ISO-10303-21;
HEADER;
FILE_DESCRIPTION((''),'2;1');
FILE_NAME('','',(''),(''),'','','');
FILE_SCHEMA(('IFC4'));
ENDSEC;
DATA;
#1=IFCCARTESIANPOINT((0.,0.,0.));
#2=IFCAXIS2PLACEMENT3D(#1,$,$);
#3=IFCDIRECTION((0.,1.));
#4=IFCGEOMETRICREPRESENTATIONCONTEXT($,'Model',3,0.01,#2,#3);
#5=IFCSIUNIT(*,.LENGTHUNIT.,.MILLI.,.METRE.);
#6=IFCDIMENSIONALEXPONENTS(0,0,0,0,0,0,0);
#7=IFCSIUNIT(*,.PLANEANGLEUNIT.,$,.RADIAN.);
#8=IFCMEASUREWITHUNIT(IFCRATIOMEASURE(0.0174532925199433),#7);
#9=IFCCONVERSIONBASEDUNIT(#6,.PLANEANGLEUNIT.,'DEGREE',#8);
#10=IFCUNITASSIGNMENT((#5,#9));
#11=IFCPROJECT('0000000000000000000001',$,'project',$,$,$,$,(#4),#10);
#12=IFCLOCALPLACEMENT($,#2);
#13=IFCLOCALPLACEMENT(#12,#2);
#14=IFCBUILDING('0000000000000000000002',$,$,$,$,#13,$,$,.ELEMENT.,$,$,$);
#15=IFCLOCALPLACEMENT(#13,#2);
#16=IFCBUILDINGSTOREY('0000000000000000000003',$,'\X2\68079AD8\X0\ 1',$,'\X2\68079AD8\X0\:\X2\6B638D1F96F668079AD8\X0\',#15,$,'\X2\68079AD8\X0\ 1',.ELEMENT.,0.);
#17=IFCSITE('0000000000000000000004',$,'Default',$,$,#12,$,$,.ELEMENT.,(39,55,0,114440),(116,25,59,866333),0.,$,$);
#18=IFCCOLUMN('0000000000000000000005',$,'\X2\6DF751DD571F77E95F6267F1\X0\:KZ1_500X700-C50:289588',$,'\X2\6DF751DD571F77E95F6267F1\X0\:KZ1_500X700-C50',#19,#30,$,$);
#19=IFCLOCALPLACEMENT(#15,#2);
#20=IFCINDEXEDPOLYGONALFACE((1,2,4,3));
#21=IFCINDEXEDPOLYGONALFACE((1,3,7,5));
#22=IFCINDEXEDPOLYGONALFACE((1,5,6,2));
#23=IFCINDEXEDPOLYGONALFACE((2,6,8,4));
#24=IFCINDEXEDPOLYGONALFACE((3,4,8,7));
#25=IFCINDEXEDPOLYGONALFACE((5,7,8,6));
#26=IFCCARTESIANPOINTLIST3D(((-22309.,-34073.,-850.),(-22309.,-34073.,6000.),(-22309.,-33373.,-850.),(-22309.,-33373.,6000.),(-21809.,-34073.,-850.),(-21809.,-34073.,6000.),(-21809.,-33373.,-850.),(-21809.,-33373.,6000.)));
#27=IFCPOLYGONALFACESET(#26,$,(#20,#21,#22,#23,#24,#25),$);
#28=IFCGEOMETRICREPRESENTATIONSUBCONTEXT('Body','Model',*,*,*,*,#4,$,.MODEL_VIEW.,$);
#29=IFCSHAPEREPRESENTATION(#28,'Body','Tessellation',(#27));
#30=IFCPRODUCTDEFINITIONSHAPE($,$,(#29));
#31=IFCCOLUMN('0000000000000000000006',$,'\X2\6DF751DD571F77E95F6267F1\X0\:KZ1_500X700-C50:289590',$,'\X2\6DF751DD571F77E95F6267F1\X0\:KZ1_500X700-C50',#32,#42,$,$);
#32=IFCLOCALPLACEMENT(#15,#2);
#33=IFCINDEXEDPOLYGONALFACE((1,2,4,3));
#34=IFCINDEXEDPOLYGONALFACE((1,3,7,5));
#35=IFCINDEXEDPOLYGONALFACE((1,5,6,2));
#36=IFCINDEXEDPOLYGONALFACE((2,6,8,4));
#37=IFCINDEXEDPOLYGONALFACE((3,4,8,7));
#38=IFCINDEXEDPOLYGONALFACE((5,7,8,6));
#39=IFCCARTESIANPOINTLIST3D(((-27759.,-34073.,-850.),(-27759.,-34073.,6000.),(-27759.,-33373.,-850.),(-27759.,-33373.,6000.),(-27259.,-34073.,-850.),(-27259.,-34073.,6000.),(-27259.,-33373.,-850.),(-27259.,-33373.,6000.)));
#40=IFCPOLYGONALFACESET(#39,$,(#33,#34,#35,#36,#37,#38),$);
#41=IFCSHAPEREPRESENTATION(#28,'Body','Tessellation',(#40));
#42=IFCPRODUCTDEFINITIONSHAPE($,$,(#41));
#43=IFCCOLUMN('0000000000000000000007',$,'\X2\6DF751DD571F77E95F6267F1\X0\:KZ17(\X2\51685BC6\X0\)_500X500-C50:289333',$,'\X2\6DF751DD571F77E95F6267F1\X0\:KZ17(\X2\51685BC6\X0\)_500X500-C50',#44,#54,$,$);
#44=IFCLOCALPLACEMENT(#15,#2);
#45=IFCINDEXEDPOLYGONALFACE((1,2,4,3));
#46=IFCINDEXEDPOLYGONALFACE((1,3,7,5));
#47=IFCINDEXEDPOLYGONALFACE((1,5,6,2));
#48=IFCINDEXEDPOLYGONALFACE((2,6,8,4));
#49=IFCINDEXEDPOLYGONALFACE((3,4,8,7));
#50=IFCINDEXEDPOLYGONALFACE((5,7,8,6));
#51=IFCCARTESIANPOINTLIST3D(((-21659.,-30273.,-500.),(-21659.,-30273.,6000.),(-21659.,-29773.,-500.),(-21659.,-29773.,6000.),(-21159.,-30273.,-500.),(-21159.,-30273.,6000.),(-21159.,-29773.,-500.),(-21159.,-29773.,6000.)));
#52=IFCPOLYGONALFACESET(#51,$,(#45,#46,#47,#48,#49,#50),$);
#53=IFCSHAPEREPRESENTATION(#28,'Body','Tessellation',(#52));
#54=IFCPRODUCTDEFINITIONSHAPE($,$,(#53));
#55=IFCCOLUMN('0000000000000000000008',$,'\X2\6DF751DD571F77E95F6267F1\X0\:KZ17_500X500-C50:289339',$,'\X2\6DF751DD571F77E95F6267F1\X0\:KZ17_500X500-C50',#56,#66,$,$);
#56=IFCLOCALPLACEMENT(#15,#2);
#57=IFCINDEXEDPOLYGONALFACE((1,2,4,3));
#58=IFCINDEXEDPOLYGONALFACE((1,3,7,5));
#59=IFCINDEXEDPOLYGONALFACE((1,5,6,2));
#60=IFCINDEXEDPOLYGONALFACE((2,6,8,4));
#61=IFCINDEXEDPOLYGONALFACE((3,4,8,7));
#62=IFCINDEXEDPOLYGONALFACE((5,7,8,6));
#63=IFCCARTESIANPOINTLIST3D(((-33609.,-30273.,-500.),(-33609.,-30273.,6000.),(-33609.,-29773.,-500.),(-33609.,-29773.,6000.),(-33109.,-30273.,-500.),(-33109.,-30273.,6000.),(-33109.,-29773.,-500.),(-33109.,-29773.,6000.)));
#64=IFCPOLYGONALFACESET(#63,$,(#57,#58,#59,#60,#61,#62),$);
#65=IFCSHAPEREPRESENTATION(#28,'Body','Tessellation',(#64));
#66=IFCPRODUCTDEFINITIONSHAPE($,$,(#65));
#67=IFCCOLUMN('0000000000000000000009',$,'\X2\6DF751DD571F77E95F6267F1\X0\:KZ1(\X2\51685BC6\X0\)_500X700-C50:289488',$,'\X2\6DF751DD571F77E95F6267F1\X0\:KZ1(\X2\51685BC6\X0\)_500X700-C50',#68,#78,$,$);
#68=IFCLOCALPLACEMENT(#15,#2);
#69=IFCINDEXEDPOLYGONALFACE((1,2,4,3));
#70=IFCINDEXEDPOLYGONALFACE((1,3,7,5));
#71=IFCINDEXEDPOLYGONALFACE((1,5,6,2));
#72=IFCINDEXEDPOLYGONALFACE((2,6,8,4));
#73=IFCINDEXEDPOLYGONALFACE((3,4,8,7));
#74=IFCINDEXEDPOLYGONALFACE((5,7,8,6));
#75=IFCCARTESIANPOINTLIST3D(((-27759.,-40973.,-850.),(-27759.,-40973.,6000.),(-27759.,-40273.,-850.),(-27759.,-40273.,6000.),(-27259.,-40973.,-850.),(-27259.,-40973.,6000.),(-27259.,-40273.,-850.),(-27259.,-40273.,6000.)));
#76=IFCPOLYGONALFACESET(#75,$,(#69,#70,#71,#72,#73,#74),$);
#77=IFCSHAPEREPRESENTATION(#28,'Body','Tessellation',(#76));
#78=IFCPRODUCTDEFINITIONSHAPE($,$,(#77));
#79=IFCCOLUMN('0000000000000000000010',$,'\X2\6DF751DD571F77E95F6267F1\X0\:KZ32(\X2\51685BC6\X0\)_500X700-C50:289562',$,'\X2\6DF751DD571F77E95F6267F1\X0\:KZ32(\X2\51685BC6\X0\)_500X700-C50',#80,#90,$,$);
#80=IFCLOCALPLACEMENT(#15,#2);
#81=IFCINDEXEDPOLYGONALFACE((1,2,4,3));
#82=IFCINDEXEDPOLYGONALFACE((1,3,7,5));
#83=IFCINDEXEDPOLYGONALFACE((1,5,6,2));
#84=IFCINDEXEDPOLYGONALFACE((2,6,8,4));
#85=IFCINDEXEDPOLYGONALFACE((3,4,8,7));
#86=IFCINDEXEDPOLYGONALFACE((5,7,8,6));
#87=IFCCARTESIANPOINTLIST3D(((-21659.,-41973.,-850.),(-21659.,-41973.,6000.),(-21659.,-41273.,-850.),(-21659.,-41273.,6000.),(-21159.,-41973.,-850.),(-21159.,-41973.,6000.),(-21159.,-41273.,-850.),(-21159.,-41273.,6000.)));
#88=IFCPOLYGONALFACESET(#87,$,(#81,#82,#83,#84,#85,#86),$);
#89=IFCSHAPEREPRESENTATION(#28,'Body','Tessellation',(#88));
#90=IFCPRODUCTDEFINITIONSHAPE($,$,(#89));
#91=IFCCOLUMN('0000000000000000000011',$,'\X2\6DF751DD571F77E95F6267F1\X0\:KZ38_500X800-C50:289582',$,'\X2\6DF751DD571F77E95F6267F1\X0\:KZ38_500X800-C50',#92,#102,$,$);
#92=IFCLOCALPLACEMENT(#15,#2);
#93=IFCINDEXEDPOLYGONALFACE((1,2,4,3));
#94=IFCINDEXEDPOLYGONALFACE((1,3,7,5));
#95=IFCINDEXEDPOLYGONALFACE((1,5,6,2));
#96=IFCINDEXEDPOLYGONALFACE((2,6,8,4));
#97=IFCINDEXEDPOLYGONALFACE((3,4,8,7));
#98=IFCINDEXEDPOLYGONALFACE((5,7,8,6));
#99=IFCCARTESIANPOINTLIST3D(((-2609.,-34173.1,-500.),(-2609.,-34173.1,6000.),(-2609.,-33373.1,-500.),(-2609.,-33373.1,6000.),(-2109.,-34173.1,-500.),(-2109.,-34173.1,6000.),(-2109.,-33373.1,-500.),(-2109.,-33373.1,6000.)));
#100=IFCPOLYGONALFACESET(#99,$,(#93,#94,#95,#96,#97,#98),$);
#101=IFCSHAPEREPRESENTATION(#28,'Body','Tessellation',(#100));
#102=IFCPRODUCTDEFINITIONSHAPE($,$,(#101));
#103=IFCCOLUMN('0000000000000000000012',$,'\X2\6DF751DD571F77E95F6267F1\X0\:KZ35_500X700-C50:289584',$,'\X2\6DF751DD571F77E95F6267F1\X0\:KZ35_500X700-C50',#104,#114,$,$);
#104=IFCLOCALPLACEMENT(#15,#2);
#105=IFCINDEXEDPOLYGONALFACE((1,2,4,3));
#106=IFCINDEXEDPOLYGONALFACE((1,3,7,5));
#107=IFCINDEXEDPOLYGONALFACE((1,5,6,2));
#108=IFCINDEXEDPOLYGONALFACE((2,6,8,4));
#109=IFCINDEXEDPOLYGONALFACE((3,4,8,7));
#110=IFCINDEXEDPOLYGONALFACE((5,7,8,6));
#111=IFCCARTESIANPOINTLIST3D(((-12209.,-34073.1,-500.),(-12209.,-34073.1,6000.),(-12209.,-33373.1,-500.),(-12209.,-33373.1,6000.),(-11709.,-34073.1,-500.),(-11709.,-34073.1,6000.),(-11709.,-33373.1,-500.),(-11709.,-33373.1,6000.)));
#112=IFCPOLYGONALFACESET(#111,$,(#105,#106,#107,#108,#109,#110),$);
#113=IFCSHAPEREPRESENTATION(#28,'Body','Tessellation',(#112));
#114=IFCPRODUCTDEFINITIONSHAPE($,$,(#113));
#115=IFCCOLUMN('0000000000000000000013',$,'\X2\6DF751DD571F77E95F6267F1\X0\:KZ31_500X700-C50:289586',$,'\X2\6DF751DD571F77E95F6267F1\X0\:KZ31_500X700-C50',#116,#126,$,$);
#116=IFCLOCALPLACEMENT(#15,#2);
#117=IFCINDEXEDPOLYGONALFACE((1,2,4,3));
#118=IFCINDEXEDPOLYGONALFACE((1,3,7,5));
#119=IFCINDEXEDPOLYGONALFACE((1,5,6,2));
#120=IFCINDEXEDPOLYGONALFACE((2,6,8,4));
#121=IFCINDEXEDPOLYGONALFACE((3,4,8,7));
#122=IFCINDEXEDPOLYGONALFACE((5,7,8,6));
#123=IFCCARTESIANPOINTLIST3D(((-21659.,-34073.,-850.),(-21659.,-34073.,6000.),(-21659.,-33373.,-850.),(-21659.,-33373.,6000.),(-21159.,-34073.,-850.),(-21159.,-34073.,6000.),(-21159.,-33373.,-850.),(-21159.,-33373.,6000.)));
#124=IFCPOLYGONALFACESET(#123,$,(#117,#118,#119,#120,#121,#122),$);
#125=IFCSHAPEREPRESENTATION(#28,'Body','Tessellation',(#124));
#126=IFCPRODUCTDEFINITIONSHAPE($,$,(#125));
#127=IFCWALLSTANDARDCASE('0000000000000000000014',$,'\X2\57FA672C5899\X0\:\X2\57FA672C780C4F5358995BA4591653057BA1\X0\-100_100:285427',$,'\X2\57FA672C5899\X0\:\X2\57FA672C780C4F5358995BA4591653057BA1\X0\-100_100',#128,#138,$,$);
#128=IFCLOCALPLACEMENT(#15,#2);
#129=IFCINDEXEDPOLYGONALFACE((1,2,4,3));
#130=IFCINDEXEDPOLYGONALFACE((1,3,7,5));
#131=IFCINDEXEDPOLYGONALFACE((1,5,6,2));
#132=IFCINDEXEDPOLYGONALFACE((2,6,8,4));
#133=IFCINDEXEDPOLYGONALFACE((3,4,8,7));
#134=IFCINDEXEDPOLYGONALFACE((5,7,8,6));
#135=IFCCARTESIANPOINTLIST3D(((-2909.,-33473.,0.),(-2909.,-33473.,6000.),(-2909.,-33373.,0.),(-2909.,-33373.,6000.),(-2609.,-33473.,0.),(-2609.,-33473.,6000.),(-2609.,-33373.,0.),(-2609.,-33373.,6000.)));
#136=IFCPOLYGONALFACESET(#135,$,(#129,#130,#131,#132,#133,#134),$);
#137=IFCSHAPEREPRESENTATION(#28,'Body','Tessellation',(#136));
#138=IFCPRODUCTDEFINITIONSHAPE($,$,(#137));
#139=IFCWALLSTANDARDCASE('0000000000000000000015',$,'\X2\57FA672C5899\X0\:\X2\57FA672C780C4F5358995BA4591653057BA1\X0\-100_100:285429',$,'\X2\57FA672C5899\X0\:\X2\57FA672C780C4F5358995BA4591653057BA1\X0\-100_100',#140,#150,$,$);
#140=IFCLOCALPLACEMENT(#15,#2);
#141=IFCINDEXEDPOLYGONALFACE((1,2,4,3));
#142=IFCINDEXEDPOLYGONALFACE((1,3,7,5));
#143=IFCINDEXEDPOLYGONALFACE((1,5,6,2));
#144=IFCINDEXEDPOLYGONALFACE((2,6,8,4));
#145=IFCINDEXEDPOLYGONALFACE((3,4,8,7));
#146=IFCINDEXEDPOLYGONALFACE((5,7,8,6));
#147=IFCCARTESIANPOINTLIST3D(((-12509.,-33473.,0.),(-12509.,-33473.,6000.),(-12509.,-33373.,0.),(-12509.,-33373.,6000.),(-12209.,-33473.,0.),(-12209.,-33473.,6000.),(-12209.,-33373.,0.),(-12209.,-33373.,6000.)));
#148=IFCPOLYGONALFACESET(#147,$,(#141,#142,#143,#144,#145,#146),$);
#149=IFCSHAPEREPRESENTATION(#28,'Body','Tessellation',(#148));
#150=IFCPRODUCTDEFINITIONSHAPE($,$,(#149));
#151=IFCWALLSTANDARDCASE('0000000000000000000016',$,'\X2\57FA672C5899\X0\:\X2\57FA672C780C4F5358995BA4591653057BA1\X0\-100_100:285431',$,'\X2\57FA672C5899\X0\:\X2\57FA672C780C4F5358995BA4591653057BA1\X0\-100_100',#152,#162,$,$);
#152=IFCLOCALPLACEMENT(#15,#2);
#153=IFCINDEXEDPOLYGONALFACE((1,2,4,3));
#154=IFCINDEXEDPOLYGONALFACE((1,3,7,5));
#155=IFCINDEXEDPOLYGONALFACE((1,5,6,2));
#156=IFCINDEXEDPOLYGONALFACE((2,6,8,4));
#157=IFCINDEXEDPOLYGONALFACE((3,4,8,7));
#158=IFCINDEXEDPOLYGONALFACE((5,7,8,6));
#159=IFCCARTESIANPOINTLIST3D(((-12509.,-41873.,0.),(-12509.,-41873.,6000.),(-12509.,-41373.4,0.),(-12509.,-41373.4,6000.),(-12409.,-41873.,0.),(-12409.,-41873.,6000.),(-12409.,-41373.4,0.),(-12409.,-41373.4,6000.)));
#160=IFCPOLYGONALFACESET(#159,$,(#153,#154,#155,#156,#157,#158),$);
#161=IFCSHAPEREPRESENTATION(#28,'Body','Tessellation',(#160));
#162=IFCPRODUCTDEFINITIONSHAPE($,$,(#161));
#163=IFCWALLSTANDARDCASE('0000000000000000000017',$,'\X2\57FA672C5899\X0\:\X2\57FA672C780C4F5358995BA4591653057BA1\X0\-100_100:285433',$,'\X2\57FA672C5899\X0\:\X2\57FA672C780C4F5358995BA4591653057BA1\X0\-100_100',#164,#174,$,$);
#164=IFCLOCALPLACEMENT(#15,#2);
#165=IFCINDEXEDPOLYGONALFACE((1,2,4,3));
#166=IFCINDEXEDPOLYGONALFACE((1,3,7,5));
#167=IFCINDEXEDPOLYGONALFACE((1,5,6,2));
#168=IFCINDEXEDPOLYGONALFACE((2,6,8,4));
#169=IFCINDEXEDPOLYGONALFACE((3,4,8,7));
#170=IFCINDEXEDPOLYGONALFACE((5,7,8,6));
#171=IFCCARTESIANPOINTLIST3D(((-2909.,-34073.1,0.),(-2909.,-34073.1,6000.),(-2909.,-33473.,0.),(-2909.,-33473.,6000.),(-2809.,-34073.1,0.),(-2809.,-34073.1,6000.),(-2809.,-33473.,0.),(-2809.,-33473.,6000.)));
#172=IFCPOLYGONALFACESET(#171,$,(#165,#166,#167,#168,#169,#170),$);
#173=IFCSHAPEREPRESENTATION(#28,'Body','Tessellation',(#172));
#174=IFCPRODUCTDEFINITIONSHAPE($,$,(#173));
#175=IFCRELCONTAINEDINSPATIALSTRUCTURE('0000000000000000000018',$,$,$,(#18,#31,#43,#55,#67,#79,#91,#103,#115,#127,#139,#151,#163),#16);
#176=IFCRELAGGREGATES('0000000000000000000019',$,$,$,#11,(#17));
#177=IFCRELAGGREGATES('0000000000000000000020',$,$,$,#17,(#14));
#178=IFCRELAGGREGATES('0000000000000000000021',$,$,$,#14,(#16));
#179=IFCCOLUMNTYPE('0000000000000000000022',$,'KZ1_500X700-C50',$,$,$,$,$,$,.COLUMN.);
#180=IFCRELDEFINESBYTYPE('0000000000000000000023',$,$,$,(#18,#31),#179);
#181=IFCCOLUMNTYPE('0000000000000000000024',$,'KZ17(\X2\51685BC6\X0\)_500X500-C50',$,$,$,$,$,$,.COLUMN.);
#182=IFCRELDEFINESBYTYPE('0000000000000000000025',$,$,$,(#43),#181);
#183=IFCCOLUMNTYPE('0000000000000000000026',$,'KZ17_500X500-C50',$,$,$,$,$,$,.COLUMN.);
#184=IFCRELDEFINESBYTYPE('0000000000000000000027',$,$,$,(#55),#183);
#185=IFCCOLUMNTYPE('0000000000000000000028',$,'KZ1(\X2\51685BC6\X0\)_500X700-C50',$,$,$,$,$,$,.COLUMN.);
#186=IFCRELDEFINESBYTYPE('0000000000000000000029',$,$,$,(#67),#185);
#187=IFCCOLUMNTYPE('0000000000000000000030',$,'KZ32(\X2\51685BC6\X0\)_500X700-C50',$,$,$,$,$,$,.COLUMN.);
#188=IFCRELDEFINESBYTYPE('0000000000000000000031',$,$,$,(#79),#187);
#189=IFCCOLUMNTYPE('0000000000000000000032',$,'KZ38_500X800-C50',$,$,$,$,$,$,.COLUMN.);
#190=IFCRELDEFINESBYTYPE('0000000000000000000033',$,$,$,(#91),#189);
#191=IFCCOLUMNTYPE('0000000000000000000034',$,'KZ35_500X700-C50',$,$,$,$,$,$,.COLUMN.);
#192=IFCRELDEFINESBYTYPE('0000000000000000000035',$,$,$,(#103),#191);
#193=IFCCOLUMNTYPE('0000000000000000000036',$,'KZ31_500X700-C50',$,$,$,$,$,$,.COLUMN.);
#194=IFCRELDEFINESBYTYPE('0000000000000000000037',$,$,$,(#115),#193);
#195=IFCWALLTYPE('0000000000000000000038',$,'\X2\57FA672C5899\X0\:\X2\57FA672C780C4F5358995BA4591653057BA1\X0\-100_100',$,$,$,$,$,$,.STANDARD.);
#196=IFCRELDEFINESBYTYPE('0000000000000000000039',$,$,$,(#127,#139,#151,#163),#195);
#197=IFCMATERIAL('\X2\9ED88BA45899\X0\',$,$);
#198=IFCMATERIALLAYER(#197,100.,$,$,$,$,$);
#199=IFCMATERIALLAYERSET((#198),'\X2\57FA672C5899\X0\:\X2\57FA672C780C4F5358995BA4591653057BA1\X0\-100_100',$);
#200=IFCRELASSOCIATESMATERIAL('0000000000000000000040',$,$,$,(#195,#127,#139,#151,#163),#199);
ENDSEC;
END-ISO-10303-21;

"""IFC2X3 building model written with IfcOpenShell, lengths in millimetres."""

from ifc_helpers import new_model, entity, si_unit, converted_unit, direction, frame, frame_2d, origin, origin_2d_with_axis, place, context, subcontext, project, spatial, rectangle, extrude, source, transform, mapped, material, layer, layer_set, layer_usage, type_object, type_shapes, element, save


model = new_model("IFC2X3")

# Units and contexts
model_context = context("Model", 3, precision=0.01, world=origin(), true_north=direction((0.0, 1.0)))
body_context = subcontext(model_context, "Body", "Model", "MODEL_VIEW")
ifc_project = project(units=[si_unit("LENGTHUNIT", "METRE", prefix="MILLI"), converted_unit("PLANEANGLEUNIT", "DEGREE", entity("IfcRatioMeasure", 0.0174532925199433), si_unit("PLANEANGLEUNIT", "RADIAN"), dimensions=[0, 0, 0, 0, 0, 0, 0])], contexts=[model_context])

# Site, building, storey
site_placement = place(None, origin())
site = spatial("IfcSite", under=ifc_project, at=site_placement, Name="Default", CompositionType="ELEMENT", RefLatitude=(39, 55, 0, 114440), RefLongitude=(116, 25, 59, 866333), RefElevation=0.0)
building_placement = place(site_placement, origin())
building = spatial("IfcBuilding", under=site, at=building_placement, CompositionType="ELEMENT")
storey_placement = place(building_placement, origin())
storey = spatial("IfcBuildingStorey", under=building, at=storey_placement, Name="标高 1", ObjectType="标高:正负零标高", LongName="标高 1", CompositionType="ELEMENT", Elevation=0.0)

# Columns
column_type_1 = type_object("IfcColumnType", Name="KZ1_500X700-C50", PredefinedType="COLUMN")
shared_shape_1 = source(origin(), body_context, "Body", "SweptSolid", [
    extrude(rectangle(XDim=700.0, YDim=500.0, at=origin_2d_with_axis()), frame((0.0, 0.0, -850.0), z_axis=(0.0, 0.0, 1.0), x_axis=(0.0, -1.0, 0.0)), (0.0, 0.0, 1.0), 6850.0),
])
type_shapes(column_type_1, [shared_shape_1])
for number, where, name in (
    (1, (-22059.0, -33723.0, 0.0), "混凝土矩形柱:KZ1_500X700-C50:289588"),
    (2, (-27509.0, -33723.0, 0.0), "混凝土矩形柱:KZ1_500X700-C50:289590"),
):
    element("IfcColumn", number, at=place(building_placement, frame(where)), inside=storey, type_object=column_type_1, Name=name, ObjectType="混凝土矩形柱:KZ1_500X700-C50", context=body_context, shape_type="MappedRepresentation", body=[
        mapped(shared_shape_1, transform((0.0, 0.0, 0.0), scale=1.0)),
    ])
column_type_2 = type_object("IfcColumnType", Name="KZ17(全密)_500X500-C50", PredefinedType="COLUMN")
shared_shape_2 = source(origin(), body_context, "Body", "SweptSolid", [
    extrude(rectangle(XDim=500.0, YDim=500.0, at=origin_2d_with_axis()), frame((0.0, 0.0, -500.0), z_axis=(0.0, 0.0, 1.0), x_axis=(0.0, -1.0, 0.0)), (0.0, 0.0, 1.0), 6500.0),
])
type_shapes(column_type_2, [shared_shape_2])
column_1_placement = place(building_placement, frame((-21409.0, -30023.0, 0.0)))
element("IfcColumn", 3, at=column_1_placement, inside=storey, type_object=column_type_2, Name="混凝土矩形柱:KZ17(全密)_500X500-C50:289333", ObjectType="混凝土矩形柱:KZ17(全密)_500X500-C50", context=body_context, shape_type="MappedRepresentation", body=[
    mapped(shared_shape_2, transform((0.0, 0.0, 0.0), scale=1.0)),
])
column_type_3 = type_object("IfcColumnType", Name="KZ17_500X500-C50", PredefinedType="COLUMN")
shared_shape_3 = source(origin(), body_context, "Body", "SweptSolid", [
    extrude(rectangle(XDim=500.0, YDim=500.0, at=origin_2d_with_axis()), frame((0.0, 0.0, -500.0), z_axis=(0.0, 0.0, 1.0), x_axis=(0.0, -1.0, 0.0)), (0.0, 0.0, 1.0), 6500.0),
])
type_shapes(column_type_3, [shared_shape_3])
column_2_placement = place(building_placement, frame((-33359.0, -30023.0, 0.0)))
element("IfcColumn", 4, at=column_2_placement, inside=storey, type_object=column_type_3, Name="混凝土矩形柱:KZ17_500X500-C50:289339", ObjectType="混凝土矩形柱:KZ17_500X500-C50", context=body_context, shape_type="MappedRepresentation", body=[
    mapped(shared_shape_3, transform((0.0, 0.0, 0.0), scale=1.0)),
])
column_type_4 = type_object("IfcColumnType", Name="KZ1(全密)_500X700-C50", PredefinedType="COLUMN")
shared_shape_4 = source(origin(), body_context, "Body", "SweptSolid", [
    extrude(rectangle(XDim=700.0, YDim=500.0, at=origin_2d_with_axis()), frame((0.0, 0.0, -850.0), z_axis=(0.0, 0.0, 1.0), x_axis=(0.0, -1.0, 0.0)), (0.0, 0.0, 1.0), 6850.0),
])
type_shapes(column_type_4, [shared_shape_4])
column_3_placement = place(building_placement, frame((-27509.0, -40623.0, 0.0)))
element("IfcColumn", 5, at=column_3_placement, inside=storey, type_object=column_type_4, Name="混凝土矩形柱:KZ1(全密)_500X700-C50:289488", ObjectType="混凝土矩形柱:KZ1(全密)_500X700-C50", context=body_context, shape_type="MappedRepresentation", body=[
    mapped(shared_shape_4, transform((0.0, 0.0, 0.0), scale=1.0)),
])
column_type_5 = type_object("IfcColumnType", Name="KZ32(全密)_500X700-C50", PredefinedType="COLUMN")
shared_shape_5 = source(origin(), body_context, "Body", "SweptSolid", [
    extrude(rectangle(XDim=700.0, YDim=500.0, at=origin_2d_with_axis()), frame((0.0, 0.0, -850.0), z_axis=(0.0, 0.0, 1.0), x_axis=(0.0, -1.0, 0.0)), (0.0, 0.0, 1.0), 6850.0),
])
type_shapes(column_type_5, [shared_shape_5])
column_4_placement = place(building_placement, frame((-21409.0, -41623.0, 0.0)))
element("IfcColumn", 6, at=column_4_placement, inside=storey, type_object=column_type_5, Name="混凝土矩形柱:KZ32(全密)_500X700-C50:289562", ObjectType="混凝土矩形柱:KZ32(全密)_500X700-C50", context=body_context, shape_type="MappedRepresentation", body=[
    mapped(shared_shape_5, transform((0.0, 0.0, 0.0), scale=1.0)),
])
column_type_6 = type_object("IfcColumnType", Name="KZ38_500X800-C50", PredefinedType="COLUMN")
shared_shape_6 = source(origin(), body_context, "Body", "SweptSolid", [
    extrude(rectangle(XDim=800.0, YDim=500.0, at=origin_2d_with_axis()), frame((0.0, 0.0, -500.0), z_axis=(0.0, 0.0, 1.0), x_axis=(0.0, -1.0, 0.0)), (0.0, 0.0, 1.0), 6500.0),
])
type_shapes(column_type_6, [shared_shape_6])
column_5_placement = place(building_placement, frame((-2359.0, -33773.1, 0.0)))
element("IfcColumn", 7, at=column_5_placement, inside=storey, type_object=column_type_6, Name="混凝土矩形柱:KZ38_500X800-C50:289582", ObjectType="混凝土矩形柱:KZ38_500X800-C50", context=body_context, shape_type="MappedRepresentation", body=[
    mapped(shared_shape_6, transform((0.0, 0.0, 0.0), scale=1.0)),
])
column_type_7 = type_object("IfcColumnType", Name="KZ35_500X700-C50", PredefinedType="COLUMN")
shared_shape_7 = source(origin(), body_context, "Body", "SweptSolid", [
    extrude(rectangle(XDim=700.0, YDim=500.0, at=origin_2d_with_axis()), frame((0.0, 0.0, -500.0), z_axis=(0.0, 0.0, 1.0), x_axis=(0.0, -1.0, 0.0)), (0.0, 0.0, 1.0), 6500.0),
])
type_shapes(column_type_7, [shared_shape_7])
column_6_placement = place(building_placement, frame((-11959.0, -33723.1, 0.0)))
element("IfcColumn", 8, at=column_6_placement, inside=storey, type_object=column_type_7, Name="混凝土矩形柱:KZ35_500X700-C50:289584", ObjectType="混凝土矩形柱:KZ35_500X700-C50", context=body_context, shape_type="MappedRepresentation", body=[
    mapped(shared_shape_7, transform((0.0, 0.0, 0.0), scale=1.0)),
])
column_type_8 = type_object("IfcColumnType", Name="KZ31_500X700-C50", PredefinedType="COLUMN")
shared_shape_8 = source(origin(), body_context, "Body", "SweptSolid", [
    extrude(rectangle(XDim=700.0, YDim=500.0, at=origin_2d_with_axis()), frame((0.0, 0.0, -850.0), z_axis=(0.0, 0.0, 1.0), x_axis=(0.0, -1.0, 0.0)), (0.0, 0.0, 1.0), 6850.0),
])
type_shapes(column_type_8, [shared_shape_8])
column_7_placement = place(building_placement, frame((-21409.0, -33723.0, 0.0)))
element("IfcColumn", 9, at=column_7_placement, inside=storey, type_object=column_type_8, Name="混凝土矩形柱:KZ31_500X700-C50:289586", ObjectType="混凝土矩形柱:KZ31_500X700-C50", context=body_context, shape_type="MappedRepresentation", body=[
    mapped(shared_shape_8, transform((0.0, 0.0, 0.0), scale=1.0)),
])

# Walls
ifc_material = material(Name="默认墙")
ifc_layer_1 = layer(ifc_material, 100.0)
ifc_layer_set_1 = layer_set([ifc_layer_1], Name="基本墙:基本砌体墙室外包管-100_100")
ifc_layer_usage_1 = layer_usage(ifc_layer_set_1, "AXIS2", "NEGATIVE", 50.0)
wall_type_1 = type_object("IfcWallType", Name="基本墙:基本砌体墙室外包管-100_100", PredefinedType="STANDARD", material=ifc_layer_set_1)
wall_1_placement = place(building_placement, frame((-2909.0, -33423.0, 0.0)))
element("IfcWallStandardCase", 10, at=wall_1_placement, inside=storey, type_object=wall_type_1, material=ifc_layer_usage_1, Name="基本墙:基本砌体墙室外包管-100_100:285427", ObjectType="基本墙:基本砌体墙室外包管-100_100", context=body_context, shape_type="SweptSolid", body=[
    extrude(rectangle(XDim=300.0, YDim=100.0, at=frame_2d((150.0, 0.0), x_axis=(-1.0, 0.0))), origin(), (0.0, 0.0, 1.0), 6000.0),
])
ifc_layer_usage_2 = layer_usage(ifc_layer_set_1, "AXIS2", "NEGATIVE", 50.0)
wall_2_placement = place(building_placement, frame((-12509.0, -33423.0, 0.0)))
element("IfcWallStandardCase", 11, at=wall_2_placement, inside=storey, type_object=wall_type_1, material=ifc_layer_usage_2, Name="基本墙:基本砌体墙室外包管-100_100:285429", ObjectType="基本墙:基本砌体墙室外包管-100_100", context=body_context, shape_type="SweptSolid", body=[
    extrude(rectangle(XDim=300.0, YDim=100.0, at=frame_2d((150.0, 0.0), x_axis=(-1.0, 0.0))), origin(), (0.0, 0.0, 1.0), 6000.0),
])
ifc_layer_usage_3 = layer_usage(ifc_layer_set_1, "AXIS2", "NEGATIVE", 50.0)
wall_3_placement = place(building_placement, frame((-12459.0, -41373.4, 0.0), z_axis=(0.0, 0.0, 1.0), x_axis=(0.0, -1.0, 0.0)))
element("IfcWallStandardCase", 12, at=wall_3_placement, inside=storey, type_object=wall_type_1, material=ifc_layer_usage_3, Name="基本墙:基本砌体墙室外包管-100_100:285431", ObjectType="基本墙:基本砌体墙室外包管-100_100", context=body_context, shape_type="SweptSolid", body=[
    extrude(rectangle(XDim=499.6, YDim=100.0, at=frame_2d((249.8, 0.0), x_axis=(-1.0, 0.0))), origin(), (0.0, 0.0, 1.0), 6000.0),
])
ifc_layer_usage_4 = layer_usage(ifc_layer_set_1, "AXIS2", "NEGATIVE", 50.0)
wall_4_placement = place(building_placement, frame((-2859.0, -33473.0, 0.0), z_axis=(0.0, 0.0, 1.0), x_axis=(0.0, -1.0, 0.0)))
element("IfcWallStandardCase", 13, at=wall_4_placement, inside=storey, type_object=wall_type_1, material=ifc_layer_usage_4, Name="基本墙:基本砌体墙室外包管-100_100:285433", ObjectType="基本墙:基本砌体墙室外包管-100_100", context=body_context, shape_type="SweptSolid", body=[
    extrude(rectangle(XDim=600.1, YDim=100.0, at=frame_2d((300.0, 0.0), x_axis=(-1.0, 0.0))), origin(), (0.0, 0.0, 1.0), 6000.0),
])

save(model, "model.ifc")
